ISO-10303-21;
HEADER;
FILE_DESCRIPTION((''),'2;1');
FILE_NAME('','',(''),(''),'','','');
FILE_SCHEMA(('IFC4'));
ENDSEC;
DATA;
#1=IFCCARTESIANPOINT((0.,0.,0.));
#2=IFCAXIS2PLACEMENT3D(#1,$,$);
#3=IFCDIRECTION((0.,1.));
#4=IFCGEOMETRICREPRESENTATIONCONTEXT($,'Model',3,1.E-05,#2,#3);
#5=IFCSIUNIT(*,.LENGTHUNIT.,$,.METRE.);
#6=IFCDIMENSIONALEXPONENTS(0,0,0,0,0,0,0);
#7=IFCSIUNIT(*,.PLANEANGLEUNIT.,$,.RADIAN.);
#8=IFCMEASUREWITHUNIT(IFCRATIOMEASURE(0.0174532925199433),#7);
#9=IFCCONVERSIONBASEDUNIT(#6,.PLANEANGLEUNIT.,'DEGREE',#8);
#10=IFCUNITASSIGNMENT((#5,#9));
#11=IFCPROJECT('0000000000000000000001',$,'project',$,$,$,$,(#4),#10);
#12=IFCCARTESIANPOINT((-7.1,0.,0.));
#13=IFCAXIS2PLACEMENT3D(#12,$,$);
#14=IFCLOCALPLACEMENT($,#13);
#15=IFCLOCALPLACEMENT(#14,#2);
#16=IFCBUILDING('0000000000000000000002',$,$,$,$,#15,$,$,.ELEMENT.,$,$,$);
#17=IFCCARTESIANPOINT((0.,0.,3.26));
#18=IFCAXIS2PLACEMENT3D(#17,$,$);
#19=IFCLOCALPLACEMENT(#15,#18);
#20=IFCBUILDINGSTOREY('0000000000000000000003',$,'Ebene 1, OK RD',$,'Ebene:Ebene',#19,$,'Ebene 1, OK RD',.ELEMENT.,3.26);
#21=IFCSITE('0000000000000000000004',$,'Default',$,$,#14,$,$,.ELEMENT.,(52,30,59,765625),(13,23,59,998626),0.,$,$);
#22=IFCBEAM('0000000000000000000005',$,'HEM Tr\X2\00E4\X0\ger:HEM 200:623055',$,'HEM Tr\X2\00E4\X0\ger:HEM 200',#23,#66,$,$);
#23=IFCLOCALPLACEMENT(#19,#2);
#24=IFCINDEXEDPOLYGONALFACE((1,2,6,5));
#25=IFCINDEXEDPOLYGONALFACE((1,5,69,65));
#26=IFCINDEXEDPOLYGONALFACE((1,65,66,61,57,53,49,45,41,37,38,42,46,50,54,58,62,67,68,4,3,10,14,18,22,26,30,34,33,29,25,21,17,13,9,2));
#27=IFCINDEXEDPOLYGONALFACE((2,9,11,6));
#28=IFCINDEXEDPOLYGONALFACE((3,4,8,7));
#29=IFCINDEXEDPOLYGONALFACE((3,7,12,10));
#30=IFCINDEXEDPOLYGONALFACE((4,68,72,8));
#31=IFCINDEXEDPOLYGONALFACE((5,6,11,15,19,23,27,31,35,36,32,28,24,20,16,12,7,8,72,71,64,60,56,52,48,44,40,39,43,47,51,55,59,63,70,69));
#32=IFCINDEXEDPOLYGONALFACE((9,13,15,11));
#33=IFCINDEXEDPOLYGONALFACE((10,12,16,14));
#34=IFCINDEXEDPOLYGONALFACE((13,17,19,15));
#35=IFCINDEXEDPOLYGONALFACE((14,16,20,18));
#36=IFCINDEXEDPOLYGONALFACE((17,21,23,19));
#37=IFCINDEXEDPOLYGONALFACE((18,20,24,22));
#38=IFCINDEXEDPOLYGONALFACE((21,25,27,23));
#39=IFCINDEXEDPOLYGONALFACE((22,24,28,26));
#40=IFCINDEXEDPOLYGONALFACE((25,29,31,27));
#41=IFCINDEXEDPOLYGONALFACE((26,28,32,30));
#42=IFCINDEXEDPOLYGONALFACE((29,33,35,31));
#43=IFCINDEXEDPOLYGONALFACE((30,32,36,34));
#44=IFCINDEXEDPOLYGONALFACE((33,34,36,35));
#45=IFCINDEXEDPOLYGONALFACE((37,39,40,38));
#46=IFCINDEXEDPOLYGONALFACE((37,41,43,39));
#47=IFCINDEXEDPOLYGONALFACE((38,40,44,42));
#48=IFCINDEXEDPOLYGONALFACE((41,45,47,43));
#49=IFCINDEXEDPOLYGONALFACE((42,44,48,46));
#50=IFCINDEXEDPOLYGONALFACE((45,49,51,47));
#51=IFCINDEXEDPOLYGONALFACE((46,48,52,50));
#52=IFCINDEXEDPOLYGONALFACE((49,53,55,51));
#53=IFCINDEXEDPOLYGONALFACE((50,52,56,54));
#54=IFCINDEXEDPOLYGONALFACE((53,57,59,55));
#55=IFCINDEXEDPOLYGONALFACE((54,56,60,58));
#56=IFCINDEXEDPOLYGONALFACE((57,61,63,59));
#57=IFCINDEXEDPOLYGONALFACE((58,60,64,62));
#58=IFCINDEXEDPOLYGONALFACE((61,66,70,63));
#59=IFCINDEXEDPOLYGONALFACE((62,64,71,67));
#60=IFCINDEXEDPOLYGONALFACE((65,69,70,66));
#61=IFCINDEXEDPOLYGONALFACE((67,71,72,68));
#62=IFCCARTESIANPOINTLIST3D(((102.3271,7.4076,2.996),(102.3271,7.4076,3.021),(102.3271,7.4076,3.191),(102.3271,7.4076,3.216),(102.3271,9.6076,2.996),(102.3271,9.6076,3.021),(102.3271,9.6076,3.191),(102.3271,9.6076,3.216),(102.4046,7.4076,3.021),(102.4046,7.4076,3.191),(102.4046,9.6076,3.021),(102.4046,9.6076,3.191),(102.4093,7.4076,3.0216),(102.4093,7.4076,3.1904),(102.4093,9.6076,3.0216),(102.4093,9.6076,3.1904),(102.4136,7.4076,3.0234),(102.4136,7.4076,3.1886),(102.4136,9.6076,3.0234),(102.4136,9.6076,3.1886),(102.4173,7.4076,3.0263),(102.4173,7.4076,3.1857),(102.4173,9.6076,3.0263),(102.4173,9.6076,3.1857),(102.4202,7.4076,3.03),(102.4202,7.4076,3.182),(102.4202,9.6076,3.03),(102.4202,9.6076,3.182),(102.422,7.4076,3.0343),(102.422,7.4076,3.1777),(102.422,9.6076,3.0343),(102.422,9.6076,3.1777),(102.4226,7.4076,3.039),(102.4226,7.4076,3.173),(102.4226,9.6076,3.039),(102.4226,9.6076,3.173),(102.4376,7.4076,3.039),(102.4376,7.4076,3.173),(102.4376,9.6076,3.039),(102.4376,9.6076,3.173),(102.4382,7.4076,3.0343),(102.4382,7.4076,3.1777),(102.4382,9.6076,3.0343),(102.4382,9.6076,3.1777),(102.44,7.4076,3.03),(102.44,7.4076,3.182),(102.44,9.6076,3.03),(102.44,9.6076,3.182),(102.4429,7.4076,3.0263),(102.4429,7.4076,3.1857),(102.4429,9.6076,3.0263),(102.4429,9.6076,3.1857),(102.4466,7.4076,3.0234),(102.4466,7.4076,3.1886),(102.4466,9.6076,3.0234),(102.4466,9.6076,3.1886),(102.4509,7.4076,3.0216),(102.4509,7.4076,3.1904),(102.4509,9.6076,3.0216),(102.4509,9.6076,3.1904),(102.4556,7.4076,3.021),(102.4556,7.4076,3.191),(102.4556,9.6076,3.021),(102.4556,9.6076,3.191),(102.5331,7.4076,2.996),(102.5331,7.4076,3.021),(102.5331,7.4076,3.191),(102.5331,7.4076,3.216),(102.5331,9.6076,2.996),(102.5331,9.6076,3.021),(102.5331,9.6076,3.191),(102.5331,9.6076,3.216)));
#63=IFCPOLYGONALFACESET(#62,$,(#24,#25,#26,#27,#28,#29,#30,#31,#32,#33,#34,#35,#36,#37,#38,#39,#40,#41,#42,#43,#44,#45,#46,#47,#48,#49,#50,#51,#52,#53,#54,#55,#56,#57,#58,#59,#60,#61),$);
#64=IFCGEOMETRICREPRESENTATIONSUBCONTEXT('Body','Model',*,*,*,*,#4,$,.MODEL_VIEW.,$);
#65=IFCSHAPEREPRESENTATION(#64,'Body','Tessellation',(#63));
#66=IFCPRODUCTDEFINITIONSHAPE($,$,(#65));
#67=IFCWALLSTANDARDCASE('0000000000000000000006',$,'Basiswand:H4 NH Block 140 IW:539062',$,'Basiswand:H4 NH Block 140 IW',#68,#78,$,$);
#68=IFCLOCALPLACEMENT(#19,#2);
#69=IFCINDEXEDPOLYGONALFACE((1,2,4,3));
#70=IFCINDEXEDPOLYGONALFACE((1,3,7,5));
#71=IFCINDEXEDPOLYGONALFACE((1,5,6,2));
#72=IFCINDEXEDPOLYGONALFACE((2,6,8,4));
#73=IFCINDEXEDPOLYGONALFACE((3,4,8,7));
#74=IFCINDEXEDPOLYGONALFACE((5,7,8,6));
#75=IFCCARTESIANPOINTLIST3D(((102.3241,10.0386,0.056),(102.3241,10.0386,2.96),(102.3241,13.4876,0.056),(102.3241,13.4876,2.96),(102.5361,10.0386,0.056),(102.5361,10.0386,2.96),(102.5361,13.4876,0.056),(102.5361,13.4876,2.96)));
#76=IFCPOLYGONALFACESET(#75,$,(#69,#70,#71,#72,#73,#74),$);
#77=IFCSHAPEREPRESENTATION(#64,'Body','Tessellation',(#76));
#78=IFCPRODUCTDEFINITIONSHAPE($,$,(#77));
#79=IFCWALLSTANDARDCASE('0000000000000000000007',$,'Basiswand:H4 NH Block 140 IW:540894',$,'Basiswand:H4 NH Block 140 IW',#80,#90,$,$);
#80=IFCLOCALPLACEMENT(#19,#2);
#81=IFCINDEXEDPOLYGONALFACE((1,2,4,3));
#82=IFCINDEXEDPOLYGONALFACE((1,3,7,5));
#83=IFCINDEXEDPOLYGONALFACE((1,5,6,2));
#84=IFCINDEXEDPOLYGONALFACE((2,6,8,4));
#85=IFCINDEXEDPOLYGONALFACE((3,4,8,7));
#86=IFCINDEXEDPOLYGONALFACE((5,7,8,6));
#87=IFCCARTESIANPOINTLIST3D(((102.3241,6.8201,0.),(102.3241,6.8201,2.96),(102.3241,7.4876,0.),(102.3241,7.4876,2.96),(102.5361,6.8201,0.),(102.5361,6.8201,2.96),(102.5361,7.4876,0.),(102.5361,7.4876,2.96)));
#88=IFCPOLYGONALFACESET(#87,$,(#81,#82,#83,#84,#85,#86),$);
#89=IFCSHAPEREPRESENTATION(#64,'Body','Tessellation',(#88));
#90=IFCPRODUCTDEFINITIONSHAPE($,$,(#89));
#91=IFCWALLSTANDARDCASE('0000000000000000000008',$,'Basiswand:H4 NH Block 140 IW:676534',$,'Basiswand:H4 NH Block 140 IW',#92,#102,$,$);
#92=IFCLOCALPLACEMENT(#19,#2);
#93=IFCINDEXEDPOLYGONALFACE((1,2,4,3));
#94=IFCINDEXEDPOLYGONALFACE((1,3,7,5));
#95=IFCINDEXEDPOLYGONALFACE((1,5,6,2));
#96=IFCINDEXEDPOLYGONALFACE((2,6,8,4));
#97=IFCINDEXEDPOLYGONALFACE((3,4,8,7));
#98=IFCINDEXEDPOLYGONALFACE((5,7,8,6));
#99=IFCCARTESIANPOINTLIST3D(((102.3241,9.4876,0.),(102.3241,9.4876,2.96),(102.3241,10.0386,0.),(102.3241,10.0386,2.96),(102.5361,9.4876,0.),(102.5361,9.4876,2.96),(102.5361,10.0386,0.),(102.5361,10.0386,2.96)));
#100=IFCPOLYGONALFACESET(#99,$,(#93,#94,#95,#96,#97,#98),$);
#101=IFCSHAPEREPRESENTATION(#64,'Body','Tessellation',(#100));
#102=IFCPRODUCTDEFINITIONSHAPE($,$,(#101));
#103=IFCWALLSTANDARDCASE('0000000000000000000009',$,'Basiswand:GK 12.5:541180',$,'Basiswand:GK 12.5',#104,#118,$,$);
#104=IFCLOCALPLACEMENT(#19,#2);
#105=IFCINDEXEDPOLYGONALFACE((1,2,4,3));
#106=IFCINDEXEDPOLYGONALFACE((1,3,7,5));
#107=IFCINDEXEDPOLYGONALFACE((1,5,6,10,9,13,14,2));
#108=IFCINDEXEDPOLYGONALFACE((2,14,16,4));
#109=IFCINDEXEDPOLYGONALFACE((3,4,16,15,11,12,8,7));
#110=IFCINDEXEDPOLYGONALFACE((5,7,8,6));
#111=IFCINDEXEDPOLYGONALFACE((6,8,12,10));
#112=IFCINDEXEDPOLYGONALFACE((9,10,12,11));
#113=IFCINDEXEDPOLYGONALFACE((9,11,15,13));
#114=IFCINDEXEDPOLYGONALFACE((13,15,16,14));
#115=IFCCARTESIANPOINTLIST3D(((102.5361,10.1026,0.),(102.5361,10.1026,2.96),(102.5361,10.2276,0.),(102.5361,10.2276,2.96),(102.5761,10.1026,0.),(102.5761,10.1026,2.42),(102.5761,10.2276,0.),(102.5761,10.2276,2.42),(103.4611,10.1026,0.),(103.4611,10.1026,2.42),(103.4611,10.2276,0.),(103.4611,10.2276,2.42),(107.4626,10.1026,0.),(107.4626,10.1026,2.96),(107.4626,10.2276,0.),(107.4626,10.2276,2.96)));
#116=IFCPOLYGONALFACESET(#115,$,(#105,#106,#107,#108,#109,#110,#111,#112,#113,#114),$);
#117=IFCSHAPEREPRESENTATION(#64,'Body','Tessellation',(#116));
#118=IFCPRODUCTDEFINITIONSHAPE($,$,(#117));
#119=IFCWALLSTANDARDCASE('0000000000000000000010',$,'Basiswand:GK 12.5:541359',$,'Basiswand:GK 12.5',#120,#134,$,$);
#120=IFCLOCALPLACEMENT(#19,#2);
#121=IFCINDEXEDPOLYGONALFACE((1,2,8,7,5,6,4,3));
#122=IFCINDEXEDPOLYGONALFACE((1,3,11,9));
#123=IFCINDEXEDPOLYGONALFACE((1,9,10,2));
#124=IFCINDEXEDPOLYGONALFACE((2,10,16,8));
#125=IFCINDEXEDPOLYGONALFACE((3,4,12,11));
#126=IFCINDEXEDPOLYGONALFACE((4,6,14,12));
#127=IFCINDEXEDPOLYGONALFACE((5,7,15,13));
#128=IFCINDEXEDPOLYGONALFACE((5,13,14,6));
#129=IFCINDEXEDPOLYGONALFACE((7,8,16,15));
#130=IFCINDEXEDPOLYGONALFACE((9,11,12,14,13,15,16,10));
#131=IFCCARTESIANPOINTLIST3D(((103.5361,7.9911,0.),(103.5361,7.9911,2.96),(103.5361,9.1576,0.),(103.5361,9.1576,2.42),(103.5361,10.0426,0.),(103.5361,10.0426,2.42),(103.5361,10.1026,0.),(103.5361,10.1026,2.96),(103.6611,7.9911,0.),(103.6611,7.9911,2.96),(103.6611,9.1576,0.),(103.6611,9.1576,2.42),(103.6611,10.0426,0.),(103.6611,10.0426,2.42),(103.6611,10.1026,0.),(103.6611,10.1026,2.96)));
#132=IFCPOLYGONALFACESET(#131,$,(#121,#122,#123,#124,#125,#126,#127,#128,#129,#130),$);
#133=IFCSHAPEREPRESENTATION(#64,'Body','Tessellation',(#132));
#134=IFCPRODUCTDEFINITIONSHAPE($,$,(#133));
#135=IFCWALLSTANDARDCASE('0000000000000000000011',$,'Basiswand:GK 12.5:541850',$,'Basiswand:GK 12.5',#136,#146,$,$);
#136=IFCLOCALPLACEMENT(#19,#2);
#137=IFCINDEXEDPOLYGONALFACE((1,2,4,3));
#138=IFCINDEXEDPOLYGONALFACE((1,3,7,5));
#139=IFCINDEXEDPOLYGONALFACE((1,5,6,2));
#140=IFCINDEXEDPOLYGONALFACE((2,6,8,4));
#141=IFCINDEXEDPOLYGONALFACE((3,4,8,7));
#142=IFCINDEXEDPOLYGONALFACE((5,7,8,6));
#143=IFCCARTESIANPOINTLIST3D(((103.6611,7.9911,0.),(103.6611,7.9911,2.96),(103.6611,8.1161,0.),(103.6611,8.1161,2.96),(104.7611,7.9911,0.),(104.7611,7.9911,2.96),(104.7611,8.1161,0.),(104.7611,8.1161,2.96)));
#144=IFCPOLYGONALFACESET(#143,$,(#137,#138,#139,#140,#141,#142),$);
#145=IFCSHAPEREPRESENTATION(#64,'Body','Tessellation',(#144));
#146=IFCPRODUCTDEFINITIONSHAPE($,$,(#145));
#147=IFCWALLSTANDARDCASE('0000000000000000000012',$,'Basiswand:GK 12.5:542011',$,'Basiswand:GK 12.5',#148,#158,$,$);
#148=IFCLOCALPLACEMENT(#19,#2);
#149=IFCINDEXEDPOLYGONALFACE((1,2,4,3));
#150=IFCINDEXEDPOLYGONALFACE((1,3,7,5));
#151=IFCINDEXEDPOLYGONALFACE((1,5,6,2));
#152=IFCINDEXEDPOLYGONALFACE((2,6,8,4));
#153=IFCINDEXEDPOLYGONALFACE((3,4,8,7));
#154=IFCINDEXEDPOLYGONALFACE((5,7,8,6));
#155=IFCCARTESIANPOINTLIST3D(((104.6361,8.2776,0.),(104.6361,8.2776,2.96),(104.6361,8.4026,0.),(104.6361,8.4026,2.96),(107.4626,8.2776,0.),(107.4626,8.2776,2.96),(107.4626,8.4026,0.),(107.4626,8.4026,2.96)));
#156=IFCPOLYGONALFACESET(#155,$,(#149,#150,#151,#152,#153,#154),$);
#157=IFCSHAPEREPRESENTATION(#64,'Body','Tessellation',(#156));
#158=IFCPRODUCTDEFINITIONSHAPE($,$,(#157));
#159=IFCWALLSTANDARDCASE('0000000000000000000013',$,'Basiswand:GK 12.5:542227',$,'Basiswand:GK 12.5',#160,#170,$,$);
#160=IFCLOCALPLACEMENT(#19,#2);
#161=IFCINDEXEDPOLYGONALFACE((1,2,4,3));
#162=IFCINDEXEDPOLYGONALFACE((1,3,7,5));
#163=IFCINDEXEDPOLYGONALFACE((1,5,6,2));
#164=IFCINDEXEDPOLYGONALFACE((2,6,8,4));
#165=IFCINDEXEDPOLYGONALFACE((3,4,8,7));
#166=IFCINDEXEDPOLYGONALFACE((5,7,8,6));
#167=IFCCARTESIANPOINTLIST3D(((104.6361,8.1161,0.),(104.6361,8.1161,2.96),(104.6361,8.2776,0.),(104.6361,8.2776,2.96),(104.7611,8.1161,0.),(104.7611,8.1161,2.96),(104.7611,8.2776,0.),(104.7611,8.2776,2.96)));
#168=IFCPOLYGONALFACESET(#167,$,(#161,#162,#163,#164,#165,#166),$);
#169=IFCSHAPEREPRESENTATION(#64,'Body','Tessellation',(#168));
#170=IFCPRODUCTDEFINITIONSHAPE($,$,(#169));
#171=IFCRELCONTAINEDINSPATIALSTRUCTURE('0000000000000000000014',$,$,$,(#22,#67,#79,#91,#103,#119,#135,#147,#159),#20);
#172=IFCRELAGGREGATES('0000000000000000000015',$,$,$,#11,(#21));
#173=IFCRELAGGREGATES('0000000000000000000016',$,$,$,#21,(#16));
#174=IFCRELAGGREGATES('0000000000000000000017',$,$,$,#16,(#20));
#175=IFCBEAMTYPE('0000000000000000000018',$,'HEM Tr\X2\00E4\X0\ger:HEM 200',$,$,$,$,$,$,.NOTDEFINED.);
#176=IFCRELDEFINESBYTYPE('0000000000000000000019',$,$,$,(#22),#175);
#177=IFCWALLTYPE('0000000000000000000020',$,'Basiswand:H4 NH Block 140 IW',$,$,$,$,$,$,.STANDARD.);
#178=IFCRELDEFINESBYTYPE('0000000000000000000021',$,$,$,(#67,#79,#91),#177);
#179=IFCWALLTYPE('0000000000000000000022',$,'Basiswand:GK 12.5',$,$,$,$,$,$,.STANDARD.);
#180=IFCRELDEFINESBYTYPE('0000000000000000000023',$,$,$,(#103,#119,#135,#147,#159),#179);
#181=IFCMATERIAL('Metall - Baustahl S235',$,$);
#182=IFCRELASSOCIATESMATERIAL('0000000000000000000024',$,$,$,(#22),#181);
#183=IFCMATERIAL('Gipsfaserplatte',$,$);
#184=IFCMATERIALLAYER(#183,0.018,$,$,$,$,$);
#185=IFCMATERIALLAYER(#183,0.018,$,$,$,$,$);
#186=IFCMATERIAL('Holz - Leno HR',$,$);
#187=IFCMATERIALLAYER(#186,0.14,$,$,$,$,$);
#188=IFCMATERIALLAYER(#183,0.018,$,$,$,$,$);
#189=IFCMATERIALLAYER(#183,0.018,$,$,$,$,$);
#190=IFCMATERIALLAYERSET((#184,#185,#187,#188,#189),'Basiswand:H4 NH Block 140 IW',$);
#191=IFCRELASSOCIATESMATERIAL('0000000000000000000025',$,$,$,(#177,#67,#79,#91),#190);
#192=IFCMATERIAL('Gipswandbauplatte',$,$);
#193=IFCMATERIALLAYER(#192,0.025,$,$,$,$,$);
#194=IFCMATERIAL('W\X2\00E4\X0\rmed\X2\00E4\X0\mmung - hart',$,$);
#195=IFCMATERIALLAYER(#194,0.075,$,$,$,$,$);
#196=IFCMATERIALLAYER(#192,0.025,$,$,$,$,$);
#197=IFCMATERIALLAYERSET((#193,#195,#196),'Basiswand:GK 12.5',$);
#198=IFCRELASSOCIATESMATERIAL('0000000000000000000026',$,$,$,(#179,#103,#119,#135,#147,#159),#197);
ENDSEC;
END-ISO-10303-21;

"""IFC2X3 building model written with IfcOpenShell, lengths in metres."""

from ifc_helpers import new_model, entity, si_unit, converted_unit, direction, frame, frame_2d, origin, place, context, subcontext, project, spatial, rectangle, i_section, extrude, material, layer, layer_set, layer_usage, type_object, element, save


model = new_model("IFC2X3")

# Units and contexts
model_context = context("Model", 3, precision=1e-05, world=origin(), true_north=direction((0.0, 1.0)))
body_context = subcontext(model_context, "Body", "Model", "MODEL_VIEW")
ifc_project = project(units=[si_unit("LENGTHUNIT", "METRE"), converted_unit("PLANEANGLEUNIT", "DEGREE", entity("IfcRatioMeasure", 0.0174532925199433), si_unit("PLANEANGLEUNIT", "RADIAN"), dimensions=[0, 0, 0, 0, 0, 0, 0])], contexts=[model_context])

# Site, building, storey
site_placement = place(None, frame((-7.1, 0.0, 0.0)))
site = spatial("IfcSite", under=ifc_project, at=site_placement, Name="Default", CompositionType="ELEMENT", RefLatitude=(52, 30, 59, 765625), RefLongitude=(13, 23, 59, 998626), RefElevation=0.0)
building_placement = place(site_placement, origin())
building = spatial("IfcBuilding", under=site, at=building_placement, CompositionType="ELEMENT")
storey_placement = place(building_placement, frame((0.0, 0.0, 3.26)))
storey = spatial("IfcBuildingStorey", under=building, at=storey_placement, Name="Ebene 1, OK RD", ObjectType="Ebene:Ebene", LongName="Ebene 1, OK RD", CompositionType="ELEMENT", Elevation=3.26)

# Beam
ifc_material_1 = material(Name="Metall - Baustahl S235")
beam_type = type_object("IfcBeamType", Name="HEM Träger:HEM 200", PredefinedType="NOTDEFINED")
beam_placement = place(storey_placement, frame((102.4301, 7.4076, 2.996), z_axis=(0.0, 0.0, 1.0), x_axis=(0.0, 1.0, 0.0)))
element("IfcBeam", 1, at=beam_placement, inside=storey, type_object=beam_type, material=ifc_material_1, Name="HEM Träger:HEM 200:623055", ObjectType="HEM Träger:HEM 200", context=body_context, shape_type="SweptSolid", body=[
    extrude(i_section(OverallWidth=0.206, OverallDepth=0.22, WebThickness=0.015, FlangeThickness=0.025, FilletRadius=0.018, at=frame_2d((0.0, 0.0), x_axis=(0.0, 1.0))), frame((0.0, 0.0, 0.11), z_axis=(1.0, 0.0, 0.0), x_axis=(0.0, 0.0, -1.0)), (0.0, 0.0, 1.0), 2.2),
])

# Shared definitions
ifc_material_2 = material(Name="Gipsfaserplatte")
ifc_material_3 = material(Name="Holz - Leno HR")

# Walls
ifc_layer_1 = layer(ifc_material_2, 0.018)
ifc_layer_2 = layer(ifc_material_2, 0.018)
ifc_layer_3 = layer(ifc_material_3, 0.14)
ifc_layer_4 = layer(ifc_material_2, 0.018)
ifc_layer_5 = layer(ifc_material_2, 0.018)
ifc_layer_set_1 = layer_set([ifc_layer_1, ifc_layer_2, ifc_layer_3, ifc_layer_4, ifc_layer_5], Name="Basiswand:H4 NH Block 140 IW")
ifc_layer_usage_1 = layer_usage(ifc_layer_set_1, "AXIS2", "NEGATIVE", 0.106)
wall_type_1 = type_object("IfcWallType", Name="Basiswand:H4 NH Block 140 IW", PredefinedType="STANDARD", material=ifc_layer_set_1)
wall_1_placement = place(storey_placement, frame((102.4301, 13.4876, 0.056), z_axis=(0.0, 0.0, 1.0), x_axis=(0.0, -1.0, 0.0)))
element("IfcWallStandardCase", 2, at=wall_1_placement, inside=storey, type_object=wall_type_1, material=ifc_layer_usage_1, Name="Basiswand:H4 NH Block 140 IW:539062", ObjectType="Basiswand:H4 NH Block 140 IW", context=body_context, shape_type="SweptSolid", body=[
    extrude(rectangle(XDim=3.449, YDim=0.212, at=frame_2d((1.7245, 0.0), x_axis=(-1.0, 0.0))), origin(), (0.0, 0.0, 1.0), 2.904),
])
ifc_layer_usage_2 = layer_usage(ifc_layer_set_1, "AXIS2", "NEGATIVE", 0.106)
wall_2_placement = place(storey_placement, frame((102.4301, 7.4876, 0.0), z_axis=(0.0, 0.0, 1.0), x_axis=(0.0, -1.0, 0.0)))
element("IfcWallStandardCase", 3, at=wall_2_placement, inside=storey, type_object=wall_type_1, material=ifc_layer_usage_2, Name="Basiswand:H4 NH Block 140 IW:540894", ObjectType="Basiswand:H4 NH Block 140 IW", context=body_context, shape_type="SweptSolid", body=[
    extrude(rectangle(XDim=0.6675, YDim=0.212, at=frame_2d((0.3338, 0.0), x_axis=(-1.0, 0.0))), origin(), (0.0, 0.0, 1.0), 2.96),
])
ifc_layer_usage_3 = layer_usage(ifc_layer_set_1, "AXIS2", "NEGATIVE", 0.106)
wall_3_placement = place(storey_placement, frame((102.4301, 10.0386, 0.0), z_axis=(0.0, 0.0, 1.0), x_axis=(0.0, -1.0, 0.0)))
element("IfcWallStandardCase", 4, at=wall_3_placement, inside=storey, type_object=wall_type_1, material=ifc_layer_usage_3, Name="Basiswand:H4 NH Block 140 IW:676534", ObjectType="Basiswand:H4 NH Block 140 IW", context=body_context, shape_type="SweptSolid", body=[
    extrude(rectangle(XDim=0.551, YDim=0.212, at=frame_2d((0.2755, 0.0), x_axis=(-1.0, 0.0))), origin(), (0.0, 0.0, 1.0), 2.96),
])

# Walls, openings
ifc_material_4 = material(Name="Gipswandbauplatte")
ifc_layer_6 = layer(ifc_material_4, 0.025)
ifc_material_5 = material(Name="Wärmedämmung - hart")
ifc_layer_7 = layer(ifc_material_5, 0.075)
ifc_layer_8 = layer(ifc_material_4, 0.025)
ifc_layer_set_2 = layer_set([ifc_layer_6, ifc_layer_7, ifc_layer_8], Name="Basiswand:GK 12.5")
ifc_layer_usage_4 = layer_usage(ifc_layer_set_2, "AXIS2", "NEGATIVE", 0.0625)
wall_type_2 = type_object("IfcWallType", Name="Basiswand:GK 12.5", PredefinedType="STANDARD", material=ifc_layer_set_2)
wall_4_placement = place(storey_placement, frame((102.5361, 10.1651, 0.0)))
wall_4 = element("IfcWallStandardCase", 5, at=wall_4_placement, inside=storey, type_object=wall_type_2, material=ifc_layer_usage_4, Name="Basiswand:GK 12.5:541180", ObjectType="Basiswand:GK 12.5", context=body_context, shape_type="SweptSolid", body=[
    extrude(rectangle(XDim=4.9265, YDim=0.125, at=frame_2d((2.4633, 0.0), x_axis=(-1.0, 0.0))), origin(), (0.0, 0.0, 1.0), 2.96),
])
opening_1_placement = place(wall_4_placement, frame((0.04, -0.0625, 0.0)))
element("IfcOpeningElement", 6, at=opening_1_placement, cuts=wall_4, ObjectType="Opening", context=body_context, shape_type="SweptSolid", body=[
    extrude(rectangle(XDim=2.42, YDim=0.885, at=frame_2d((1.21, 0.4425), x_axis=(1.0, 0.0))), frame((0.0, 0.0, 0.0), z_axis=(0.0, 1.0, 0.0), x_axis=(0.0, 0.0, 1.0)), (0.0, 0.0, 1.0), 0.125),
])
ifc_layer_usage_5 = layer_usage(ifc_layer_set_2, "AXIS2", "NEGATIVE", 0.0625)
wall_5_placement = place(storey_placement, frame((103.5986, 10.1026, 0.0), z_axis=(0.0, 0.0, 1.0), x_axis=(0.0, -1.0, 0.0)))
wall_5 = element("IfcWallStandardCase", 7, at=wall_5_placement, inside=storey, type_object=wall_type_2, material=ifc_layer_usage_5, Name="Basiswand:GK 12.5:541359", ObjectType="Basiswand:GK 12.5", context=body_context, shape_type="SweptSolid", body=[
    extrude(rectangle(XDim=2.1115, YDim=0.125, at=frame_2d((1.0557, 0.0), x_axis=(-1.0, 0.0))), origin(), (0.0, 0.0, 1.0), 2.96),
])
opening_2_placement = place(wall_5_placement, frame((0.06, -0.0625, 0.0)))
element("IfcOpeningElement", 8, at=opening_2_placement, cuts=wall_5, ObjectType="Opening", context=body_context, shape_type="SweptSolid", body=[
    extrude(rectangle(XDim=2.42, YDim=0.885, at=frame_2d((1.21, 0.4425), x_axis=(1.0, 0.0))), frame((0.0, 0.0, 0.0), z_axis=(0.0, 1.0, 0.0), x_axis=(0.0, 0.0, 1.0)), (0.0, 0.0, 1.0), 0.125),
])

# Walls
ifc_layer_usage_6 = layer_usage(ifc_layer_set_2, "AXIS2", "NEGATIVE", 0.0625)
wall_6_placement = place(storey_placement, frame((103.6611, 8.0536, 0.0)))
element("IfcWallStandardCase", 9, at=wall_6_placement, inside=storey, type_object=wall_type_2, material=ifc_layer_usage_6, Name="Basiswand:GK 12.5:541850", ObjectType="Basiswand:GK 12.5", context=body_context, shape_type="SweptSolid", body=[
    extrude(rectangle(XDim=1.1, YDim=0.125, at=frame_2d((0.55, 0.0), x_axis=(-1.0, 0.0))), origin(), (0.0, 0.0, 1.0), 2.96),
])
ifc_layer_usage_7 = layer_usage(ifc_layer_set_2, "AXIS2", "NEGATIVE", 0.0625)
wall_7_placement = place(storey_placement, frame((104.6361, 8.3401, 0.0)))
element("IfcWallStandardCase", 10, at=wall_7_placement, inside=storey, type_object=wall_type_2, material=ifc_layer_usage_7, Name="Basiswand:GK 12.5:542011", ObjectType="Basiswand:GK 12.5", context=body_context, shape_type="SweptSolid", body=[
    extrude(rectangle(XDim=2.8265, YDim=0.125, at=frame_2d((1.4133, 0.0), x_axis=(-1.0, 0.0))), origin(), (0.0, 0.0, 1.0), 2.96),
])
ifc_layer_usage_8 = layer_usage(ifc_layer_set_2, "AXIS2", "NEGATIVE", 0.0625)
wall_8_placement = place(storey_placement, frame((104.6986, 8.1161, 0.0), z_axis=(0.0, 0.0, 1.0), x_axis=(0.0, 1.0, 0.0)))
element("IfcWallStandardCase", 11, at=wall_8_placement, inside=storey, type_object=wall_type_2, material=ifc_layer_usage_8, Name="Basiswand:GK 12.5:542227", ObjectType="Basiswand:GK 12.5", context=body_context, shape_type="SweptSolid", body=[
    extrude(rectangle(XDim=0.1615, YDim=0.125, at=frame_2d((0.0807, 0.0), x_axis=(-1.0, 0.0))), origin(), (0.0, 0.0, 1.0), 2.96),
])

save(model, "model.ifc")
